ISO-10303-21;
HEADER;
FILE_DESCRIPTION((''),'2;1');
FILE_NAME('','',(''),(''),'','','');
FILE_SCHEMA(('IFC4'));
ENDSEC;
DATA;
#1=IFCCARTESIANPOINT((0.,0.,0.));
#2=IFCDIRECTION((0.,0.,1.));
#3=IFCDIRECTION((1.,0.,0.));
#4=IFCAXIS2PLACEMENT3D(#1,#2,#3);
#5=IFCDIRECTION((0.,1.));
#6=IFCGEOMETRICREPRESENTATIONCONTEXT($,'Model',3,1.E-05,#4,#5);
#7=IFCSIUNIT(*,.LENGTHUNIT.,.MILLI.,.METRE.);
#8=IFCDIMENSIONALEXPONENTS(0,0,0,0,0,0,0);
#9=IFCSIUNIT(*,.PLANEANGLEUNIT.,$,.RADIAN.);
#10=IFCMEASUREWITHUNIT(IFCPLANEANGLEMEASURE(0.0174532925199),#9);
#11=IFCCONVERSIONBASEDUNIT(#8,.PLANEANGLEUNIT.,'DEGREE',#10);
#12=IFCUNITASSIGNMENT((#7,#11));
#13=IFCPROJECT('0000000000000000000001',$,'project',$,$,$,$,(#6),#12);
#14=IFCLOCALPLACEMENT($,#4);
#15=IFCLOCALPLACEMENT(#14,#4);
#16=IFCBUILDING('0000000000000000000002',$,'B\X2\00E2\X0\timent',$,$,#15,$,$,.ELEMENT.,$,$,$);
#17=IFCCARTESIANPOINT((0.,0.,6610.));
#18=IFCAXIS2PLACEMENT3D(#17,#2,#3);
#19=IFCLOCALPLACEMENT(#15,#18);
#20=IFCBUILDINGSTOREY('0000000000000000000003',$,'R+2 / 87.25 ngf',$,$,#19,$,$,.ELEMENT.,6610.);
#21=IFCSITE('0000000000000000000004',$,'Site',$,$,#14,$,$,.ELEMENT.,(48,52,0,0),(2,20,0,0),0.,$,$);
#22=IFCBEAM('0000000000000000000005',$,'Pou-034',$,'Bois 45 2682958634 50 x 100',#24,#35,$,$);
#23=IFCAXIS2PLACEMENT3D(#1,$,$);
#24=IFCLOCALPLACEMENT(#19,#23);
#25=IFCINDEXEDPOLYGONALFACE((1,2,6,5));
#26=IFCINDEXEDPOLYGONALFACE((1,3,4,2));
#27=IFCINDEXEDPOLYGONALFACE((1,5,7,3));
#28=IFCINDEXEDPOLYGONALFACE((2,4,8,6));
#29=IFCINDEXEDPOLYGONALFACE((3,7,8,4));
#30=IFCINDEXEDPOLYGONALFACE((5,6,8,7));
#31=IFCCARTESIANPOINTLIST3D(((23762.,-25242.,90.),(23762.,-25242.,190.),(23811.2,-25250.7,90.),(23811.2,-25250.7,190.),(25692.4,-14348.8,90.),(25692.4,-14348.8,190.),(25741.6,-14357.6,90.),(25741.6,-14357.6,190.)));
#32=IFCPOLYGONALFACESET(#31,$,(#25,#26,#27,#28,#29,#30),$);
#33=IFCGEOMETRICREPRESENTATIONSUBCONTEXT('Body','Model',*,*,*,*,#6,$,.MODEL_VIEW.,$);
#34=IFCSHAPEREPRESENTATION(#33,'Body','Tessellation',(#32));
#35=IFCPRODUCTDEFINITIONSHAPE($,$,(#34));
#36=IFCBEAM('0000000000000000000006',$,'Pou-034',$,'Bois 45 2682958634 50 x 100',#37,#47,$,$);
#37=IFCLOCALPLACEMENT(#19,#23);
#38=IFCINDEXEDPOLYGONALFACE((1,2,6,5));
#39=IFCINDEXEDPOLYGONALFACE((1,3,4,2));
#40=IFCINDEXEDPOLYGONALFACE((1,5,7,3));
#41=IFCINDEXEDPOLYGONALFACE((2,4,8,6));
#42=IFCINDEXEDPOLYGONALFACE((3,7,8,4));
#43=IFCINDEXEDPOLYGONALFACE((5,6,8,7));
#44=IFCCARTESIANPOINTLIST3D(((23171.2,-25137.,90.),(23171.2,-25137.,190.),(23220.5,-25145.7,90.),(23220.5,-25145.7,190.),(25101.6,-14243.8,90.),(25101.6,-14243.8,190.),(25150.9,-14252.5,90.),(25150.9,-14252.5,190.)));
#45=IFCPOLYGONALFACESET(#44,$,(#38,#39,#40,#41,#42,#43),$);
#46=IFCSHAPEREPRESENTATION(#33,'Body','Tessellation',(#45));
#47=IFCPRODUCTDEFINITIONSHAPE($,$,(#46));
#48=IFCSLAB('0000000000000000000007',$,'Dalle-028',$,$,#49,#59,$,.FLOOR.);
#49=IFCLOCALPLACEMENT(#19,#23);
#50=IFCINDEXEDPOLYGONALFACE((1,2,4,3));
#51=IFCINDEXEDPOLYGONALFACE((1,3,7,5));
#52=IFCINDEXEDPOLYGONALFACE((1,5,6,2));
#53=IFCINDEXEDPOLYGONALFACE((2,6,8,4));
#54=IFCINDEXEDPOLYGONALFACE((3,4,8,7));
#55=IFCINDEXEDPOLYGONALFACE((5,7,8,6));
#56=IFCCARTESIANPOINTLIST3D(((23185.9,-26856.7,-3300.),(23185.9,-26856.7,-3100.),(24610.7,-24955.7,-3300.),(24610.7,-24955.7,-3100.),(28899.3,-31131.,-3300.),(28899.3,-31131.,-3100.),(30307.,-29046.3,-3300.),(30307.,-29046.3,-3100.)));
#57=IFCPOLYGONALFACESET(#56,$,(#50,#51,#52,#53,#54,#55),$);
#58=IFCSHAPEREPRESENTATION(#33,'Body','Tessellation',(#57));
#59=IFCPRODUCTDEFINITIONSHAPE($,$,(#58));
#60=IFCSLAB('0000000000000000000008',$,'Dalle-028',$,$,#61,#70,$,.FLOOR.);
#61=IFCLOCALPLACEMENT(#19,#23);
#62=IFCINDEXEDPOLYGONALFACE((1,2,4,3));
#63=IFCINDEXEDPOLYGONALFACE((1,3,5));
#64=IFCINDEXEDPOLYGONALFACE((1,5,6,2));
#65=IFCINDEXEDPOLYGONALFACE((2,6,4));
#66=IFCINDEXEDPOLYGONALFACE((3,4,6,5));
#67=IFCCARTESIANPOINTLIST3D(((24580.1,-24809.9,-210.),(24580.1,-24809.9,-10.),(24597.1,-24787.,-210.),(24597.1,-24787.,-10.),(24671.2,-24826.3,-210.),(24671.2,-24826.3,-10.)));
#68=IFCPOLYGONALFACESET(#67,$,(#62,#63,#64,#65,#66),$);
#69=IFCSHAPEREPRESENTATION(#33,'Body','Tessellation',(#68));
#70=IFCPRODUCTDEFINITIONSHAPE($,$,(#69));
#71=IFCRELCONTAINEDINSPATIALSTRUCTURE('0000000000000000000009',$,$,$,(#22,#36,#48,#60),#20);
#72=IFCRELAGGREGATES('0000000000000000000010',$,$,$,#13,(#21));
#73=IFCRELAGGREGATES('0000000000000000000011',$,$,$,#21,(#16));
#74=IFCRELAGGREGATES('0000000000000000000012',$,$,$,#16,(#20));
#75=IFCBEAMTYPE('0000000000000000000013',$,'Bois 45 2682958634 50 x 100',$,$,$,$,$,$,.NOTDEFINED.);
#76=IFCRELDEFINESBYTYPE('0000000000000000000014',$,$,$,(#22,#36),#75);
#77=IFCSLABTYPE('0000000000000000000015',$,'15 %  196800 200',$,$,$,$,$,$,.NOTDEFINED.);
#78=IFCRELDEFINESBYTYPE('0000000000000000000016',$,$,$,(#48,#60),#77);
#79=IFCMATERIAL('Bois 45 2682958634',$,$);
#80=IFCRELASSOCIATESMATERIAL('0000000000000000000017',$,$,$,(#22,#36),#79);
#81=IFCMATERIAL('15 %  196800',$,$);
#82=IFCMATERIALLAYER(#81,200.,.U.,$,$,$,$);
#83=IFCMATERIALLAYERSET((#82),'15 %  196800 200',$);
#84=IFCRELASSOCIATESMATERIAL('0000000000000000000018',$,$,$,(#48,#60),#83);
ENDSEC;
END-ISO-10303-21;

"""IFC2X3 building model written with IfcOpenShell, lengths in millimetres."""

from ifc_helpers import new_model, entity, si_unit, converted_unit, direction, frame, frame_2d, origin_with_axes, place, context, subcontext, project, spatial, polyline, rectangle, outline, extrude, material, layer, layer_set, layer_usage, type_object, element, save


model = new_model("IFC2X3")

# Units and contexts
model_context = context("Model", 3, precision=1e-05, world=origin_with_axes(), true_north=direction((0.0, 1.0)))
body_context = subcontext(model_context, "Body", "Model", "MODEL_VIEW")
ifc_project = project(units=[si_unit("LENGTHUNIT", "METRE", prefix="MILLI"), converted_unit("PLANEANGLEUNIT", "DEGREE", entity("IfcPlaneAngleMeasure", 0.0174532925199), si_unit("PLANEANGLEUNIT", "RADIAN"), dimensions=[0, 0, 0, 0, 0, 0, 0])], contexts=[model_context])

# Site, building, storey
site_placement = place(None, origin_with_axes())
site = spatial("IfcSite", under=ifc_project, at=site_placement, Name="Site", CompositionType="ELEMENT", RefLatitude=(48, 52, 0, 0), RefLongitude=(2, 20, 0, 0), RefElevation=0.0)
building_placement = place(site_placement, origin_with_axes())
building = spatial("IfcBuilding", under=site, at=building_placement, Name="Bâtiment", CompositionType="ELEMENT")
storey_placement = place(building_placement, frame((0.0, 0.0, 6610.0), z_axis=(0.0, 0.0, 1.0), x_axis=(1.0, 0.0, 0.0)))
storey = spatial("IfcBuildingStorey", under=building, at=storey_placement, Name="R+2 / 87.25 ngf", CompositionType="ELEMENT", Elevation=6610.0)

# Beams
ifc_material_1 = material(Name="Bois 45 2682958634")
beam_type_1 = type_object("IfcBeamType", Name="Bois 45 2682958634 50 x 100", PredefinedType="NOTDEFINED")
for number, where, z_axis, x_axis, name in (
    (1, (23786.6, -25246.4, 190.0), (0.0, 0.0, 1.0), (0.984659, -0.174492, 0.0), "Pou-034"),
    (2, (23195.8, -25141.3, 190.0), (0.0, 0.0, 1.0), (0.984659, -0.174492, 0.0), "Pou-034"),
):
    element("IfcBeam", number, at=place(storey_placement, frame(where, z_axis=z_axis, x_axis=x_axis)), inside=storey, type_object=beam_type_1, material=ifc_material_1, Name=name, ObjectType="Bois 45 2682958634 50 x 100", context=body_context, shape_type="SweptSolid", body=[
        extrude(rectangle(XDim=100.0, YDim=50.0, at=frame_2d((-50.0, 0.0), x_axis=(1.0, 0.0))), frame((0.0, 0.0, 0.0), z_axis=(0.0, 1.0, 0.0), x_axis=(0.0, 0.0, 1.0)), (0.0, 0.0, 1.0), 11062.9),
    ])

# Slabs
ifc_material_2 = material(Name="15 %  196800")
ifc_layer_1 = layer(ifc_material_2, 200.0, ventilated="UNKNOWN")
ifc_layer_set_1 = layer_set([ifc_layer_1], Name="15 %  196800 200")
ifc_layer_usage_1 = layer_usage(ifc_layer_set_1, "AXIS3", "NEGATIVE", 200.0)
slab_type = type_object("IfcSlabType", Name="15 %  196800 200", PredefinedType="NOTDEFINED")
slab_1_placement = place(storey_placement, frame((23185.9, -26856.7, -3100.0), z_axis=(0.0, 0.0, 1.0), x_axis=(1.0, 0.0, 0.0)))
element("IfcSlab", 3, at=slab_1_placement, inside=storey, type_object=slab_type, material=ifc_layer_usage_1, Name="Dalle-028", PredefinedType="FLOOR", context=body_context, shape_type="SweptSolid", body=[
    extrude(outline(polyline([(0.0, 0.0), (5713.4, -4274.3), (7121.1, -2189.5), (1424.8, 1901.0), (0.0, 0.0)])), frame((0.0, 0.0, -200.0), z_axis=(0.0, 0.0, 1.0), x_axis=(1.0, 0.0, 0.0)), (0.0, 0.0, 1.0), 200.0),
])
ifc_layer_usage_2 = layer_usage(ifc_layer_set_1, "AXIS3", "NEGATIVE", 200.0)
slab_2_placement = place(storey_placement, frame((24597.1, -24787.0, -10.0), z_axis=(0.0, 0.0, 1.0), x_axis=(1.0, 0.0, 0.0)))
element("IfcSlab", 4, at=slab_2_placement, inside=storey, type_object=slab_type, material=ifc_layer_usage_2, Name="Dalle-028", PredefinedType="FLOOR", context=body_context, shape_type="SweptSolid", body=[
    extrude(outline(polyline([(0.0, 0.0), (-17.0, -23.0), (74.1, -39.4), (0.0, 0.0)])), frame((0.0, 0.0, -200.0), z_axis=(0.0, 0.0, 1.0), x_axis=(1.0, 0.0, 0.0)), (0.0, 0.0, 1.0), 200.0),
])

save(model, "model.ifc")
